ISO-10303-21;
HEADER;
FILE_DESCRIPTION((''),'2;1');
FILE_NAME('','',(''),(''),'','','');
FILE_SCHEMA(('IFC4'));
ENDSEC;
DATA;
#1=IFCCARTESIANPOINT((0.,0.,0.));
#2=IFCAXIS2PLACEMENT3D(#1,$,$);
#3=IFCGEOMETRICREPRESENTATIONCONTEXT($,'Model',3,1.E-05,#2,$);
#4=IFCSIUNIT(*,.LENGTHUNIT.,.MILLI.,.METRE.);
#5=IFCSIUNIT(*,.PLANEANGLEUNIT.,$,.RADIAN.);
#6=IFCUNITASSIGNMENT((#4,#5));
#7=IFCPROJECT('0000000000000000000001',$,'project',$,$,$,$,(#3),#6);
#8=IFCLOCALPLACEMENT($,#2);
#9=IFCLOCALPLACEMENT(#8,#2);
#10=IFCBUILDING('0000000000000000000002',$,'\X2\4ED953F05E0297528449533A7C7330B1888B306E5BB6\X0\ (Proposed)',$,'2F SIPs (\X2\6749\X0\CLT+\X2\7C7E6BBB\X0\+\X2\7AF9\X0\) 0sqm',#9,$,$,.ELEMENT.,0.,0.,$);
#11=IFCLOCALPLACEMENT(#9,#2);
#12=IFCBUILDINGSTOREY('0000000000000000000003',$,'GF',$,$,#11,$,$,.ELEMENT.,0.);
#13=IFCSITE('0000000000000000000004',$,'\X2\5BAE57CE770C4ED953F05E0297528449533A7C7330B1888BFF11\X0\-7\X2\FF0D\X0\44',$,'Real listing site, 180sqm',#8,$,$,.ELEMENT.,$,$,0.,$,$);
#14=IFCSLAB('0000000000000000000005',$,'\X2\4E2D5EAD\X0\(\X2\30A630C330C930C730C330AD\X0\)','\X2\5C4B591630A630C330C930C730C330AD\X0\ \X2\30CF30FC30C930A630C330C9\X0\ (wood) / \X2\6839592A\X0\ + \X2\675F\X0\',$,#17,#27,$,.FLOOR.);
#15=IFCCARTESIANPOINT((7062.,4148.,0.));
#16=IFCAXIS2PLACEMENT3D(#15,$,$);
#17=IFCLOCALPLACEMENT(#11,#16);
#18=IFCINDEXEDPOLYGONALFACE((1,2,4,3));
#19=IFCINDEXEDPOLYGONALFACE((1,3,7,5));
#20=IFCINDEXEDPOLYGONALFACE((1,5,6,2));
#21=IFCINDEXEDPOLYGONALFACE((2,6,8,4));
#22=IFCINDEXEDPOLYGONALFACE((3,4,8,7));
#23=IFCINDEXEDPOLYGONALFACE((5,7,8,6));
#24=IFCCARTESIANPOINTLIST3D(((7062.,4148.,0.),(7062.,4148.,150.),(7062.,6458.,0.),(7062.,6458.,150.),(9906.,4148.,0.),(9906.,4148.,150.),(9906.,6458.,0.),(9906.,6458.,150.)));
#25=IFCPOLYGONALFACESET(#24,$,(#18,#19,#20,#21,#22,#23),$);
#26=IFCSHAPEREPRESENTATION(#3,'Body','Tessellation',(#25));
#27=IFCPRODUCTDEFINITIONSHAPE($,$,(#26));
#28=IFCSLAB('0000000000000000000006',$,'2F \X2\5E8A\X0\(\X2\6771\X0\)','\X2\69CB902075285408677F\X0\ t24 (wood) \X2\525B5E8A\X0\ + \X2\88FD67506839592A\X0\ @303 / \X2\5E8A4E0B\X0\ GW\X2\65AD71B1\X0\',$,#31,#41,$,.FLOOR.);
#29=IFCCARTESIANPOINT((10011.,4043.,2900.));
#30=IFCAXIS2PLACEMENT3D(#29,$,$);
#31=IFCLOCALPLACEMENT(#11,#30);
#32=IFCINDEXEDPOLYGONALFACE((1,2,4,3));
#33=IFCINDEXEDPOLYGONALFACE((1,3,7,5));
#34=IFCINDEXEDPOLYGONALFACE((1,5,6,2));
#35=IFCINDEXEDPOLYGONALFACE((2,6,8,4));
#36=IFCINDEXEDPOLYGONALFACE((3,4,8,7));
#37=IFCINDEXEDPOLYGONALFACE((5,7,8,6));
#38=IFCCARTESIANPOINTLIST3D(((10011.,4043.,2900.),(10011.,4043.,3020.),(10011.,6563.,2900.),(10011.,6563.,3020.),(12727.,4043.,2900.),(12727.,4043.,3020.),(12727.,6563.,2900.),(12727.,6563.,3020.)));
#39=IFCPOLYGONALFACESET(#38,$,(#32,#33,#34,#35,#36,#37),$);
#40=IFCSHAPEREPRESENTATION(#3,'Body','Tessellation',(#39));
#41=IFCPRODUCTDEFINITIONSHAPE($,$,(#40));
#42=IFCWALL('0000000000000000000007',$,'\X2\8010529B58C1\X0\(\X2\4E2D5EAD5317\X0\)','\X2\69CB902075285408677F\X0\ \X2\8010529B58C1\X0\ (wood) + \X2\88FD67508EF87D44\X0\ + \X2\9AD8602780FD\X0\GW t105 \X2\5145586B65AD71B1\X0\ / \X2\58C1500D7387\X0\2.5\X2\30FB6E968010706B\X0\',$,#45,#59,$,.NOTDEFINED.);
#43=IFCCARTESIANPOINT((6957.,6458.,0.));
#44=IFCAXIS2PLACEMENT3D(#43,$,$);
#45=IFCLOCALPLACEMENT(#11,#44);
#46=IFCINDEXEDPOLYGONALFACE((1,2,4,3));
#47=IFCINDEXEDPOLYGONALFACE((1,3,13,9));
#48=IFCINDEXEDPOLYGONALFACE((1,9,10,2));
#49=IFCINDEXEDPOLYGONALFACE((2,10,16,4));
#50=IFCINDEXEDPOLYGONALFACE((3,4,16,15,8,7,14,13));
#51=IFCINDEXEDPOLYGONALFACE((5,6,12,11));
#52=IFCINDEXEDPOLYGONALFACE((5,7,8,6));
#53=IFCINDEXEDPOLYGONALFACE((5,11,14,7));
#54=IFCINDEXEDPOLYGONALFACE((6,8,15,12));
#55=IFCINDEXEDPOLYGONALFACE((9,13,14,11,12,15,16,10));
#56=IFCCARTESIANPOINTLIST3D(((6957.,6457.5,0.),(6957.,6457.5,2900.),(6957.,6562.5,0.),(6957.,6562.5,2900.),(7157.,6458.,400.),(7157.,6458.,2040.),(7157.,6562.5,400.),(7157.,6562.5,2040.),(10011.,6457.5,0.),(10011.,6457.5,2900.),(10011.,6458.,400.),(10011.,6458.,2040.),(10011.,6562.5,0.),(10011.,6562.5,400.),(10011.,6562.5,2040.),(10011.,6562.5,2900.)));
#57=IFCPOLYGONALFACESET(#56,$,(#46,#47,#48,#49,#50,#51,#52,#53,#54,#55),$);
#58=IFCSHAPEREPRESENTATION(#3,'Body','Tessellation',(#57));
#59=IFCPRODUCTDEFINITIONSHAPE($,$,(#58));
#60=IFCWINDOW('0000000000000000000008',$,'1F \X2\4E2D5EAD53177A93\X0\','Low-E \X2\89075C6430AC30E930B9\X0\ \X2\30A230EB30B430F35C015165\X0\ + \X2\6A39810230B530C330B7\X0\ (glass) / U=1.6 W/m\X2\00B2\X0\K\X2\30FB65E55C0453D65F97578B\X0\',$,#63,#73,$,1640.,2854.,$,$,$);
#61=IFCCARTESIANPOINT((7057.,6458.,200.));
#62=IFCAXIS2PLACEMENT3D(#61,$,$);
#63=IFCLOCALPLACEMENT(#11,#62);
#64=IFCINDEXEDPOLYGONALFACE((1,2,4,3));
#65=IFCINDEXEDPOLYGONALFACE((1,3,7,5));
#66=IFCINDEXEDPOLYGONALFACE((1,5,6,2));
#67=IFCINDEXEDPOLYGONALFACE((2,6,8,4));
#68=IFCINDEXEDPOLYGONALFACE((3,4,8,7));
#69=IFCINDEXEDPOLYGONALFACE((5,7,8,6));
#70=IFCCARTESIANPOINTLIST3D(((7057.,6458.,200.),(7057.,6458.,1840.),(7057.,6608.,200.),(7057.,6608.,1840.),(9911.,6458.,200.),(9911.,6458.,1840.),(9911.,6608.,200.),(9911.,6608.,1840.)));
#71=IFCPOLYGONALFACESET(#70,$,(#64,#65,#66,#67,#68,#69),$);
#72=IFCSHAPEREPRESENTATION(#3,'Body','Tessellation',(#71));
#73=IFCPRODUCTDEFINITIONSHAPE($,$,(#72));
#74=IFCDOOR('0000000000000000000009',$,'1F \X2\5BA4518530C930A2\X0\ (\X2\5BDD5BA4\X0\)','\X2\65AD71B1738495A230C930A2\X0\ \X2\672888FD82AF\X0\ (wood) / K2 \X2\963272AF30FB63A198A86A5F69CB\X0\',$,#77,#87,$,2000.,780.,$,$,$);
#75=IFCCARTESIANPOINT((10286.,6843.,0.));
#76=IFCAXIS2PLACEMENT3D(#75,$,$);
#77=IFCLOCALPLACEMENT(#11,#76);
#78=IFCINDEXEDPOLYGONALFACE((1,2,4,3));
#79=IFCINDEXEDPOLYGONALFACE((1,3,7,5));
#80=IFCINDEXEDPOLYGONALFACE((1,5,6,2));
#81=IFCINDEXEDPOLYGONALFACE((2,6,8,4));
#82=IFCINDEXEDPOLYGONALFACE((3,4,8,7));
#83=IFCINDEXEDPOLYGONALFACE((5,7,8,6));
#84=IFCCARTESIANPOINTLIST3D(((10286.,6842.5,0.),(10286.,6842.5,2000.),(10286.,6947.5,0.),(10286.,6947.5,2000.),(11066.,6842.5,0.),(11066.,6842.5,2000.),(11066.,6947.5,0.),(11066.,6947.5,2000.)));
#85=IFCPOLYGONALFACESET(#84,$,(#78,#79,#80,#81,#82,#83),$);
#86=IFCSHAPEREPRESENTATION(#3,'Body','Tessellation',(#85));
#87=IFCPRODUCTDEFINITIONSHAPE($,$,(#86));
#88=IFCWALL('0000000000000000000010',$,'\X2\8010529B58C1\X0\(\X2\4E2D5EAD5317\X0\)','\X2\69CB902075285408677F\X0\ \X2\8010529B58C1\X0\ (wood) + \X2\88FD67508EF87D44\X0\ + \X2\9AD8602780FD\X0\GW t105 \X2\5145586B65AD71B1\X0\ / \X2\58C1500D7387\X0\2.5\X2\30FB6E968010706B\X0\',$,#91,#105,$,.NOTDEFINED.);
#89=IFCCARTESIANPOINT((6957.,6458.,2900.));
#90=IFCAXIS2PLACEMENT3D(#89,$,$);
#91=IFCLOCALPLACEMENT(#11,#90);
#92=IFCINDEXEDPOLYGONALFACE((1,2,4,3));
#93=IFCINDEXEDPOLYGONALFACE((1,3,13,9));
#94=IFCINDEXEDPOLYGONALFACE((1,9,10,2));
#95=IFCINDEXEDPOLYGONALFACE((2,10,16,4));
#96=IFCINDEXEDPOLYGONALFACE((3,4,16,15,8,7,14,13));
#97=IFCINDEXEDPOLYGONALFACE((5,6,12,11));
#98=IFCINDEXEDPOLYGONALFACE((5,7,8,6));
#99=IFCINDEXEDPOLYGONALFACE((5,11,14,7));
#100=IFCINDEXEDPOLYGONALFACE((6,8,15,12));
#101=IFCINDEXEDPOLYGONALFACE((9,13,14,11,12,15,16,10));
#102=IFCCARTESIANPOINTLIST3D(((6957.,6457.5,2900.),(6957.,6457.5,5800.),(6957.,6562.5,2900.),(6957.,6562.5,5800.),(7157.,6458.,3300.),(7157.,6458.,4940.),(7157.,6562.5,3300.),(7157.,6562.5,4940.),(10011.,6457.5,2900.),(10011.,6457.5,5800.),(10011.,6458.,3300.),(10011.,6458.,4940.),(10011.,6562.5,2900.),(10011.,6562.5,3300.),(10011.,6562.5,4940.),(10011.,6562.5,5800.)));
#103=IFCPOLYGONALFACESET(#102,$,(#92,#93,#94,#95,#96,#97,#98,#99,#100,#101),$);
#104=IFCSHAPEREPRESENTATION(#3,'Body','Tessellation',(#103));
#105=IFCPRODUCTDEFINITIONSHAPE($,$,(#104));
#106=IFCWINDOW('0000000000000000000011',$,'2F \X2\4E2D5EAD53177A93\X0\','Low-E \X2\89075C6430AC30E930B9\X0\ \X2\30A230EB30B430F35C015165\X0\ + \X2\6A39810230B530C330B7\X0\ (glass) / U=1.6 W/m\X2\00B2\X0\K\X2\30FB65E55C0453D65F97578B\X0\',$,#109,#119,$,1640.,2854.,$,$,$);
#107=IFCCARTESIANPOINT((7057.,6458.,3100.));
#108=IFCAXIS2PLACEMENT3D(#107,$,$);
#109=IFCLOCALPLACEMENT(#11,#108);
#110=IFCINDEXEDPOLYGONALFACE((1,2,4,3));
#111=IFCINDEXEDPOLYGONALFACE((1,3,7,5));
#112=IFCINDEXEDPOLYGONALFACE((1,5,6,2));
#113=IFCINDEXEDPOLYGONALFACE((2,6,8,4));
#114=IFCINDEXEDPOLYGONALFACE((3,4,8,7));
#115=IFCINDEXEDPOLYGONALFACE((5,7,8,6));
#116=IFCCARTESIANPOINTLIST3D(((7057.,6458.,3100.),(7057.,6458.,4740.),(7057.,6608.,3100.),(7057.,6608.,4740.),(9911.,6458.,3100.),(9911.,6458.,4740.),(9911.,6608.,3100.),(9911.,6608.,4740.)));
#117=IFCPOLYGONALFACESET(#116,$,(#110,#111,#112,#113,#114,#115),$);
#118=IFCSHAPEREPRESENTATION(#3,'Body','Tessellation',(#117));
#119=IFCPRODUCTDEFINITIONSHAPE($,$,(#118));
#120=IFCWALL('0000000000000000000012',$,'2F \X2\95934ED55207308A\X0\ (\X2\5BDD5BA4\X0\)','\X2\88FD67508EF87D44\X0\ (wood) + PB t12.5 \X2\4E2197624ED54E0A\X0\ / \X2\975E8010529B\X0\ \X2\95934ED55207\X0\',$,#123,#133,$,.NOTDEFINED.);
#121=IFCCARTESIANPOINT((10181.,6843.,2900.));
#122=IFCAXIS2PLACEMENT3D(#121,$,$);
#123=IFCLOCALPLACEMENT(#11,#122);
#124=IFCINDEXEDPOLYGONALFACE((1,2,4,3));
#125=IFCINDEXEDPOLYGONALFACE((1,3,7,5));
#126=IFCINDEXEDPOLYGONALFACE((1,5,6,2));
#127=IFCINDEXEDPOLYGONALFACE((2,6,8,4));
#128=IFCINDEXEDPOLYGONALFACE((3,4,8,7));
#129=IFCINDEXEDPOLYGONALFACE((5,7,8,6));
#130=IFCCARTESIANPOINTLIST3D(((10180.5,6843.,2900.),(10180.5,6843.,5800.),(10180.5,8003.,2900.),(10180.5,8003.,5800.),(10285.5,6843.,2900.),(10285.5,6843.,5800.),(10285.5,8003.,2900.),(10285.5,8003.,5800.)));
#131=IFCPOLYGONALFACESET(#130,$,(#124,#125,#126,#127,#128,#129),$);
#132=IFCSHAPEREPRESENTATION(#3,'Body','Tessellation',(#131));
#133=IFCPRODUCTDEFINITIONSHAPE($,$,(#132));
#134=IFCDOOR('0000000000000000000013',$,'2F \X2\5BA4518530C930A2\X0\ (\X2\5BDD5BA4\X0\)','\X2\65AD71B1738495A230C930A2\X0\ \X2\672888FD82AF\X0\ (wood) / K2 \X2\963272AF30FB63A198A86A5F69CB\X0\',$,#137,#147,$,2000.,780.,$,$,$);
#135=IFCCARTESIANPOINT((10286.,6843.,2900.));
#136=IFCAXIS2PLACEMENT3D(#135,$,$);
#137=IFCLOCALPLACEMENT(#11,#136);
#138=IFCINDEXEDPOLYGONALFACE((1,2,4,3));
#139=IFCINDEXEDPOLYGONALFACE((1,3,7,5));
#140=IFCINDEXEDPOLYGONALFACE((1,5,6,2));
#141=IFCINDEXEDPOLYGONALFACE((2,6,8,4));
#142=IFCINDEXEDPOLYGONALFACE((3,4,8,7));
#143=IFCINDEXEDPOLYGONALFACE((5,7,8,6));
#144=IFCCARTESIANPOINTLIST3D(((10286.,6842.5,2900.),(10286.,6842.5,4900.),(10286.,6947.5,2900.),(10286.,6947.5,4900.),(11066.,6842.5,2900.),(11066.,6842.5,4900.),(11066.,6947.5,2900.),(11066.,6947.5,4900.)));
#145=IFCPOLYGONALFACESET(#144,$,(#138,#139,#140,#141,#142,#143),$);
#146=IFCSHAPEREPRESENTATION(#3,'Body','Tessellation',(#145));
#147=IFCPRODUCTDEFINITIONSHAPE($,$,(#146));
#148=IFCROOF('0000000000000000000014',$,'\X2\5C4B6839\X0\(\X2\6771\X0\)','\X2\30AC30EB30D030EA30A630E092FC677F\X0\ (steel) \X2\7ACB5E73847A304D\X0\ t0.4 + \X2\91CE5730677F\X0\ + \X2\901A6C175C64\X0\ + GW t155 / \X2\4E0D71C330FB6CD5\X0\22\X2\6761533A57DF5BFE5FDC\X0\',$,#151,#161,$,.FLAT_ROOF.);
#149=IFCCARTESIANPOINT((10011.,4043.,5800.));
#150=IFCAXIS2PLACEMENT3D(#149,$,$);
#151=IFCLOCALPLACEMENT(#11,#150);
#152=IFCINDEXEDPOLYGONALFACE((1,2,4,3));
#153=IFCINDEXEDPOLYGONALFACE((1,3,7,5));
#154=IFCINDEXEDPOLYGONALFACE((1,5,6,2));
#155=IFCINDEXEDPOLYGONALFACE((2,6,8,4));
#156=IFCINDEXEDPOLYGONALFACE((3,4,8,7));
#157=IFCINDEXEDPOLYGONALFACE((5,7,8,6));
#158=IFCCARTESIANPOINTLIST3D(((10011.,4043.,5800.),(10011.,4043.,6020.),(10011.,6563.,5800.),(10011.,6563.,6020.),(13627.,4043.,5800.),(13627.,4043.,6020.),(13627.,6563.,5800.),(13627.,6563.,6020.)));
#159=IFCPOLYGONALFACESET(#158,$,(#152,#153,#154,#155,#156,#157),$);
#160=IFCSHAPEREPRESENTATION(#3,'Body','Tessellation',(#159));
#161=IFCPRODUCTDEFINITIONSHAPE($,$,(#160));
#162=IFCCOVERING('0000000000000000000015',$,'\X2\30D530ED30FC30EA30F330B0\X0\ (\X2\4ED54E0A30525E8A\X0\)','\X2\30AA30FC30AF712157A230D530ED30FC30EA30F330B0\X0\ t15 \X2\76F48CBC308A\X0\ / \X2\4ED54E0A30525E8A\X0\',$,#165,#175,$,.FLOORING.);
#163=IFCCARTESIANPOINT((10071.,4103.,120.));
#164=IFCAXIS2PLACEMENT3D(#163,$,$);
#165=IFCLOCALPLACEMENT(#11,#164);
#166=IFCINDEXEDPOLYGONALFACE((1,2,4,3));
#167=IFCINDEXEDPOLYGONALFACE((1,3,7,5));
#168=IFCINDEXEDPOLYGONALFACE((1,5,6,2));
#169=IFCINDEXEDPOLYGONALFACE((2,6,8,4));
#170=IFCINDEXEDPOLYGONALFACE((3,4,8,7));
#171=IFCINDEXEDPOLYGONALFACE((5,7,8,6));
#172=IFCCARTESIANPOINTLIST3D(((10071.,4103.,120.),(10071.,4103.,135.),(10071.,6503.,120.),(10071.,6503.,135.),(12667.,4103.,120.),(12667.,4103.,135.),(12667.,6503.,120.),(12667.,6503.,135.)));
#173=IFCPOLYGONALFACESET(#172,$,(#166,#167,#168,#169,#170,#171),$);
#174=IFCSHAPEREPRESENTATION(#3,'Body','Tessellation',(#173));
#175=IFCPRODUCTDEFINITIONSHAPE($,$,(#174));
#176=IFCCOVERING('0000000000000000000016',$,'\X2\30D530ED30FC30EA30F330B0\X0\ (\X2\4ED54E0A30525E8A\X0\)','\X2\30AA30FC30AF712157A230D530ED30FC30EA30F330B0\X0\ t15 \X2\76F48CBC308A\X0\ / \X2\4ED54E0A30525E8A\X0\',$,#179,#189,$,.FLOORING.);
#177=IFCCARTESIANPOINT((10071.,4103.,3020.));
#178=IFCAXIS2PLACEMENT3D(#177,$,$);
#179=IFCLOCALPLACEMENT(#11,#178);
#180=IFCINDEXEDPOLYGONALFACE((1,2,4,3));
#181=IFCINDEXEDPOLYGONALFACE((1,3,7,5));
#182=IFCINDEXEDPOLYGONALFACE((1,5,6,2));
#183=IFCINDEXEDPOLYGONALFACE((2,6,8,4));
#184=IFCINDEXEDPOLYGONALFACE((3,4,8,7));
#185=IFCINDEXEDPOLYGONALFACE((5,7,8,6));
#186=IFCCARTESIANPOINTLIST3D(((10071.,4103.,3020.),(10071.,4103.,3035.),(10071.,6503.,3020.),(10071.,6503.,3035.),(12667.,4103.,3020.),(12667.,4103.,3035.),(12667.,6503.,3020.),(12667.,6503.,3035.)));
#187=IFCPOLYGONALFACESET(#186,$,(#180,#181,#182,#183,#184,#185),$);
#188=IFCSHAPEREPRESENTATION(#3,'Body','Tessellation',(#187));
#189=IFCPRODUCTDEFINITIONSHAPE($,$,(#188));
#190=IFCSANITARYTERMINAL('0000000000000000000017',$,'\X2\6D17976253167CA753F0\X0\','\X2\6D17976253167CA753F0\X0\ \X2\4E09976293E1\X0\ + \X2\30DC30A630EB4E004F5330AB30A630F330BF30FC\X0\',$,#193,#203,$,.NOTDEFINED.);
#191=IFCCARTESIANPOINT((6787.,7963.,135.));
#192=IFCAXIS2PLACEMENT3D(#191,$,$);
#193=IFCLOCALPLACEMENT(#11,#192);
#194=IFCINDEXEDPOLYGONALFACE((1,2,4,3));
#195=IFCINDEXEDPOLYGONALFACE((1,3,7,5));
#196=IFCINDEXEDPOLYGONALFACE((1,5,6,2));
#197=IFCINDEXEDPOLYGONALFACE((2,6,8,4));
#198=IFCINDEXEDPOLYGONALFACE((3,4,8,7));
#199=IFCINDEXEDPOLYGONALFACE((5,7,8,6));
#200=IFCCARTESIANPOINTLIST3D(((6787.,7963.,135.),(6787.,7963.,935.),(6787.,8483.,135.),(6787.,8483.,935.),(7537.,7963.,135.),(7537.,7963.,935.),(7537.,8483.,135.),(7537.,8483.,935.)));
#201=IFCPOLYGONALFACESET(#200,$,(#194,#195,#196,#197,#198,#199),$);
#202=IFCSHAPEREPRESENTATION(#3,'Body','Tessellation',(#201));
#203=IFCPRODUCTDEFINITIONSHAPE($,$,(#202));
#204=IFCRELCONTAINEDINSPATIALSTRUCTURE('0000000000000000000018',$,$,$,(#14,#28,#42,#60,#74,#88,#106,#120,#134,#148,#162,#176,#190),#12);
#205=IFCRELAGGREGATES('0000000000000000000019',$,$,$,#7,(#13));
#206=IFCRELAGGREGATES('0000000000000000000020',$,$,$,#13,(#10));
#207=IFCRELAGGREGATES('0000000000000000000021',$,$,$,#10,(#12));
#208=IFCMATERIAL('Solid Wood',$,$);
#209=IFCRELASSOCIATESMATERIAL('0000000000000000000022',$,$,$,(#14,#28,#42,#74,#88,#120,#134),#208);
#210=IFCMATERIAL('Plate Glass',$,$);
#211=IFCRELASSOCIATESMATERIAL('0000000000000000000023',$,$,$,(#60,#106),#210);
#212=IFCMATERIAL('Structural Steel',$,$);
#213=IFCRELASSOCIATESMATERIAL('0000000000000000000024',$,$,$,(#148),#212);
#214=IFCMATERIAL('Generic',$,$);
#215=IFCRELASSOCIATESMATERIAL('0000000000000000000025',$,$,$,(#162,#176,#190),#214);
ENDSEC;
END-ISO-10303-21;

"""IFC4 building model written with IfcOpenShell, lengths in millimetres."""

from ifc_helpers import new_model, si_unit, frame, frame_2d, origin, place, context, project, spatial, rectangle, extrude, material, element, fill, save


model = new_model("IFC4")

# Units and contexts
model_context = context("Model", 3, precision=1e-05, world=origin())
ifc_project = project(units=[si_unit("LENGTHUNIT", "METRE", prefix="MILLI"), si_unit("PLANEANGLEUNIT", "RADIAN")], contexts=[model_context])

# Site, building, storey
site_placement = place(None, origin())
site = spatial("IfcSite", under=ifc_project, at=site_placement, Name="宮城県仙台市青葉区米ケ袋１-7－44", ObjectType="Real listing site, 180sqm", CompositionType="ELEMENT", RefElevation=0.0)
building_placement = place(site_placement, origin())
building = spatial("IfcBuilding", under=site, at=building_placement, Name="仙台市青葉区米ケ袋の家 (Proposed)", ObjectType="2F SIPs (杉CLT+籾殻+竹) 0sqm", CompositionType="ELEMENT", ElevationOfRefHeight=0.0, ElevationOfTerrain=0.0)
storey_placement = place(building_placement, origin())
storey = spatial("IfcBuildingStorey", under=building, at=storey_placement, Name="GF", CompositionType="ELEMENT", Elevation=0.0)

# Slabs
ifc_material_1 = material(Name="Solid Wood")
slab_1_placement = place(storey_placement, frame((7062.0, 4148.0, 0.0)))
element("IfcSlab", 1, at=slab_1_placement, inside=storey, material=ifc_material_1, Name="中庭(ウッドデッキ)", Description="屋外ウッドデッキ ハードウッド (wood) / 根太 + 束", PredefinedType="FLOOR", context=model_context, shape_type="SweptSolid", body=[
    extrude(rectangle(XDim=2844.0, YDim=2310.0, at=frame_2d((1422.0, 1155.0))), frame((7062.0, 4148.0, 0.0)), (0.0, 0.0, 1.0), 150.0),
])
slab_2_placement = place(storey_placement, frame((10011.0, 4043.0, 2900.0)))
element("IfcSlab", 2, at=slab_2_placement, inside=storey, material=ifc_material_1, Name="2F 床(東)", Description="構造用合板 t24 (wood) 剛床 + 製材根太 @303 / 床下 GW断熱", PredefinedType="FLOOR", context=model_context, shape_type="SweptSolid", body=[
    extrude(rectangle(XDim=2716.0, YDim=2520.0, at=frame_2d((1358.0, 1260.0))), frame((10011.0, 4043.0, 2900.0)), (0.0, 0.0, 1.0), 120.0),
])

# Wall, opening, window
wall_1_placement = place(storey_placement, frame((6957.0, 6458.0, 0.0)))
wall_1 = element("IfcWall", 3, at=wall_1_placement, inside=storey, material=ifc_material_1, Name="耐力壁(中庭北)", Description="構造用合板 耐力壁 (wood) + 製材軸組 + 高性能GW t105 充填断熱 / 壁倍率2.5・準耐火", PredefinedType="NOTDEFINED", context=model_context, shape_type="SweptSolid", body=[
    extrude(rectangle(XDim=3054.0, YDim=105.0, at=frame_2d((1527.0, 52.0))), frame((6957.0, 6458.0, 0.0)), (0.0, 0.0, 1.0), 2900.0),
])
opening_1_placement = place(storey_placement, frame((7057.0, 6458.0, 200.0)))
opening_1 = element("IfcOpeningElement", 4, at=opening_1_placement, cuts=wall_1, PredefinedType="NOTDEFINED", context=model_context, shape_type="SweptSolid", body=[
    extrude(rectangle(XDim=2854.0, YDim=150.0, at=frame_2d((1427.0, 75.0))), frame((7057.0, 6458.0, 200.0)), (0.0, 0.0, 1.0), 1640.0),
])
ifc_material_2 = material(Name="Plate Glass")
window_1_placement = place(storey_placement, frame((7057.0, 6458.0, 200.0)))
window_1 = element("IfcWindow", 5, at=window_1_placement, inside=storey, material=ifc_material_2, Name="1F 中庭北窓", Description="Low-E 複層ガラス アルゴン封入 + 樹脂サッシ (glass) / U=1.6 W/m²K・日射取得型", OverallHeight=1640.0, OverallWidth=2854.0, context=model_context, shape_type="SweptSolid", body=[
    extrude(rectangle(XDim=2854.0, YDim=150.0, at=frame_2d((1427.0, 75.0))), frame((7057.0, 6458.0, 200.0)), (0.0, 0.0, 1.0), 1640.0),
])
fill(opening_1, window_1)

# Door
door_1_placement = place(storey_placement, frame((10286.0, 6843.0, 0.0)))
element("IfcDoor", 6, at=door_1_placement, inside=storey, material=ifc_material_1, Name="1F 室内ドア (寝室)", Description="断熱玄関ドア 木製芯 (wood) / K2 防犯・採風機構", OverallHeight=2000.0, OverallWidth=780.0, context=model_context, shape_type="SweptSolid", body=[
    extrude(rectangle(XDim=780.0, YDim=105.0, at=frame_2d((390.0, 52.0))), frame((10286.0, 6843.0, 0.0)), (0.0, 0.0, 1.0), 2000.0),
])

# Wall, opening, window
wall_2_placement = place(storey_placement, frame((6957.0, 6458.0, 2900.0)))
wall_2 = element("IfcWall", 7, at=wall_2_placement, inside=storey, material=ifc_material_1, Name="耐力壁(中庭北)", Description="構造用合板 耐力壁 (wood) + 製材軸組 + 高性能GW t105 充填断熱 / 壁倍率2.5・準耐火", PredefinedType="NOTDEFINED", context=model_context, shape_type="SweptSolid", body=[
    extrude(rectangle(XDim=3054.0, YDim=105.0, at=frame_2d((1527.0, 52.0))), frame((6957.0, 6458.0, 2900.0)), (0.0, 0.0, 1.0), 2900.0),
])
opening_2_placement = place(storey_placement, frame((7057.0, 6458.0, 3100.0)))
opening_2 = element("IfcOpeningElement", 8, at=opening_2_placement, cuts=wall_2, PredefinedType="NOTDEFINED", context=model_context, shape_type="SweptSolid", body=[
    extrude(rectangle(XDim=2854.0, YDim=150.0, at=frame_2d((1427.0, 75.0))), frame((7057.0, 6458.0, 3100.0)), (0.0, 0.0, 1.0), 1640.0),
])
window_2_placement = place(storey_placement, frame((7057.0, 6458.0, 3100.0)))
window_2 = element("IfcWindow", 9, at=window_2_placement, inside=storey, material=ifc_material_2, Name="2F 中庭北窓", Description="Low-E 複層ガラス アルゴン封入 + 樹脂サッシ (glass) / U=1.6 W/m²K・日射取得型", OverallHeight=1640.0, OverallWidth=2854.0, context=model_context, shape_type="SweptSolid", body=[
    extrude(rectangle(XDim=2854.0, YDim=150.0, at=frame_2d((1427.0, 75.0))), frame((7057.0, 6458.0, 3100.0)), (0.0, 0.0, 1.0), 1640.0),
])
fill(opening_2, window_2)

# Wall
wall_3_placement = place(storey_placement, frame((10181.0, 6843.0, 2900.0)))
element("IfcWall", 10, at=wall_3_placement, inside=storey, material=ifc_material_1, Name="2F 間仕切り (寝室)", Description="製材軸組 (wood) + PB t12.5 両面仕上 / 非耐力 間仕切", PredefinedType="NOTDEFINED", context=model_context, shape_type="SweptSolid", body=[
    extrude(rectangle(XDim=105.0, YDim=1160.0, at=frame_2d((52.0, 580.0))), frame((10181.0, 6843.0, 2900.0)), (0.0, 0.0, 1.0), 2900.0),
])

# Door
door_2_placement = place(storey_placement, frame((10286.0, 6843.0, 2900.0)))
element("IfcDoor", 11, at=door_2_placement, inside=storey, material=ifc_material_1, Name="2F 室内ドア (寝室)", Description="断熱玄関ドア 木製芯 (wood) / K2 防犯・採風機構", OverallHeight=2000.0, OverallWidth=780.0, context=model_context, shape_type="SweptSolid", body=[
    extrude(rectangle(XDim=780.0, YDim=105.0, at=frame_2d((390.0, 52.0))), frame((10286.0, 6843.0, 2900.0)), (0.0, 0.0, 1.0), 2000.0),
])

# Roof
ifc_material_3 = material(Name="Structural Steel")
for number, where, name in (
    (12, (10011.0, 4043.0, 5800.0), "屋根(東)"),
):
    element("IfcRoof", number, at=place(storey_placement, frame(where)), inside=storey, material=ifc_material_3, Name=name, Description="ガルバリウム鋼板 (steel) 立平葺き t0.4 + 野地板 + 通気層 + GW t155 / 不燃・法22条区域対応", PredefinedType="FLAT_ROOF", context=model_context, shape_type="SweptSolid", body=[
        extrude(rectangle(XDim=3616.0, YDim=2520.0, at=frame_2d((1808.0, 1260.0))), frame((10011.0, 4043.0, 5800.0)), (0.0, 0.0, 1.0), 220.0),
    ])

# Coverings
ifc_material_4 = material(Name="Generic")
covering_1_placement = place(storey_placement, frame((10071.0, 4103.0, 120.0)))
element("IfcCovering", 13, at=covering_1_placement, inside=storey, material=ifc_material_4, Name="フローリング (仕上げ床)", Description="オーク無垢フローリング t15 直貼り / 仕上げ床", PredefinedType="FLOORING", context=model_context, shape_type="SweptSolid", body=[
    extrude(rectangle(XDim=2596.0, YDim=2400.0, at=frame_2d((1298.0, 1200.0))), frame((10071.0, 4103.0, 120.0)), (0.0, 0.0, 1.0), 15.0),
])
covering_2_placement = place(storey_placement, frame((10071.0, 4103.0, 3020.0)))
element("IfcCovering", 14, at=covering_2_placement, inside=storey, material=ifc_material_4, Name="フローリング (仕上げ床)", Description="オーク無垢フローリング t15 直貼り / 仕上げ床", PredefinedType="FLOORING", context=model_context, shape_type="SweptSolid", body=[
    extrude(rectangle(XDim=2596.0, YDim=2400.0, at=frame_2d((1298.0, 1200.0))), frame((10071.0, 4103.0, 3020.0)), (0.0, 0.0, 1.0), 15.0),
])

# Sanitary terminal
sanitary_terminal_1_placement = place(storey_placement, frame((6787.0, 7963.0, 135.0)))
element("IfcSanitaryTerminal", 15, at=sanitary_terminal_1_placement, inside=storey, material=ifc_material_4, Name="洗面化粧台", Description="洗面化粧台 三面鏡 + ボウル一体カウンター", PredefinedType="NOTDEFINED", context=model_context, shape_type="SweptSolid", body=[
    extrude(rectangle(XDim=750.0, YDim=520.0, at=frame_2d((375.0, 260.0))), frame((6787.0, 7963.0, 135.0)), (0.0, 0.0, 1.0), 800.0),
])

save(model, "model.ifc")
